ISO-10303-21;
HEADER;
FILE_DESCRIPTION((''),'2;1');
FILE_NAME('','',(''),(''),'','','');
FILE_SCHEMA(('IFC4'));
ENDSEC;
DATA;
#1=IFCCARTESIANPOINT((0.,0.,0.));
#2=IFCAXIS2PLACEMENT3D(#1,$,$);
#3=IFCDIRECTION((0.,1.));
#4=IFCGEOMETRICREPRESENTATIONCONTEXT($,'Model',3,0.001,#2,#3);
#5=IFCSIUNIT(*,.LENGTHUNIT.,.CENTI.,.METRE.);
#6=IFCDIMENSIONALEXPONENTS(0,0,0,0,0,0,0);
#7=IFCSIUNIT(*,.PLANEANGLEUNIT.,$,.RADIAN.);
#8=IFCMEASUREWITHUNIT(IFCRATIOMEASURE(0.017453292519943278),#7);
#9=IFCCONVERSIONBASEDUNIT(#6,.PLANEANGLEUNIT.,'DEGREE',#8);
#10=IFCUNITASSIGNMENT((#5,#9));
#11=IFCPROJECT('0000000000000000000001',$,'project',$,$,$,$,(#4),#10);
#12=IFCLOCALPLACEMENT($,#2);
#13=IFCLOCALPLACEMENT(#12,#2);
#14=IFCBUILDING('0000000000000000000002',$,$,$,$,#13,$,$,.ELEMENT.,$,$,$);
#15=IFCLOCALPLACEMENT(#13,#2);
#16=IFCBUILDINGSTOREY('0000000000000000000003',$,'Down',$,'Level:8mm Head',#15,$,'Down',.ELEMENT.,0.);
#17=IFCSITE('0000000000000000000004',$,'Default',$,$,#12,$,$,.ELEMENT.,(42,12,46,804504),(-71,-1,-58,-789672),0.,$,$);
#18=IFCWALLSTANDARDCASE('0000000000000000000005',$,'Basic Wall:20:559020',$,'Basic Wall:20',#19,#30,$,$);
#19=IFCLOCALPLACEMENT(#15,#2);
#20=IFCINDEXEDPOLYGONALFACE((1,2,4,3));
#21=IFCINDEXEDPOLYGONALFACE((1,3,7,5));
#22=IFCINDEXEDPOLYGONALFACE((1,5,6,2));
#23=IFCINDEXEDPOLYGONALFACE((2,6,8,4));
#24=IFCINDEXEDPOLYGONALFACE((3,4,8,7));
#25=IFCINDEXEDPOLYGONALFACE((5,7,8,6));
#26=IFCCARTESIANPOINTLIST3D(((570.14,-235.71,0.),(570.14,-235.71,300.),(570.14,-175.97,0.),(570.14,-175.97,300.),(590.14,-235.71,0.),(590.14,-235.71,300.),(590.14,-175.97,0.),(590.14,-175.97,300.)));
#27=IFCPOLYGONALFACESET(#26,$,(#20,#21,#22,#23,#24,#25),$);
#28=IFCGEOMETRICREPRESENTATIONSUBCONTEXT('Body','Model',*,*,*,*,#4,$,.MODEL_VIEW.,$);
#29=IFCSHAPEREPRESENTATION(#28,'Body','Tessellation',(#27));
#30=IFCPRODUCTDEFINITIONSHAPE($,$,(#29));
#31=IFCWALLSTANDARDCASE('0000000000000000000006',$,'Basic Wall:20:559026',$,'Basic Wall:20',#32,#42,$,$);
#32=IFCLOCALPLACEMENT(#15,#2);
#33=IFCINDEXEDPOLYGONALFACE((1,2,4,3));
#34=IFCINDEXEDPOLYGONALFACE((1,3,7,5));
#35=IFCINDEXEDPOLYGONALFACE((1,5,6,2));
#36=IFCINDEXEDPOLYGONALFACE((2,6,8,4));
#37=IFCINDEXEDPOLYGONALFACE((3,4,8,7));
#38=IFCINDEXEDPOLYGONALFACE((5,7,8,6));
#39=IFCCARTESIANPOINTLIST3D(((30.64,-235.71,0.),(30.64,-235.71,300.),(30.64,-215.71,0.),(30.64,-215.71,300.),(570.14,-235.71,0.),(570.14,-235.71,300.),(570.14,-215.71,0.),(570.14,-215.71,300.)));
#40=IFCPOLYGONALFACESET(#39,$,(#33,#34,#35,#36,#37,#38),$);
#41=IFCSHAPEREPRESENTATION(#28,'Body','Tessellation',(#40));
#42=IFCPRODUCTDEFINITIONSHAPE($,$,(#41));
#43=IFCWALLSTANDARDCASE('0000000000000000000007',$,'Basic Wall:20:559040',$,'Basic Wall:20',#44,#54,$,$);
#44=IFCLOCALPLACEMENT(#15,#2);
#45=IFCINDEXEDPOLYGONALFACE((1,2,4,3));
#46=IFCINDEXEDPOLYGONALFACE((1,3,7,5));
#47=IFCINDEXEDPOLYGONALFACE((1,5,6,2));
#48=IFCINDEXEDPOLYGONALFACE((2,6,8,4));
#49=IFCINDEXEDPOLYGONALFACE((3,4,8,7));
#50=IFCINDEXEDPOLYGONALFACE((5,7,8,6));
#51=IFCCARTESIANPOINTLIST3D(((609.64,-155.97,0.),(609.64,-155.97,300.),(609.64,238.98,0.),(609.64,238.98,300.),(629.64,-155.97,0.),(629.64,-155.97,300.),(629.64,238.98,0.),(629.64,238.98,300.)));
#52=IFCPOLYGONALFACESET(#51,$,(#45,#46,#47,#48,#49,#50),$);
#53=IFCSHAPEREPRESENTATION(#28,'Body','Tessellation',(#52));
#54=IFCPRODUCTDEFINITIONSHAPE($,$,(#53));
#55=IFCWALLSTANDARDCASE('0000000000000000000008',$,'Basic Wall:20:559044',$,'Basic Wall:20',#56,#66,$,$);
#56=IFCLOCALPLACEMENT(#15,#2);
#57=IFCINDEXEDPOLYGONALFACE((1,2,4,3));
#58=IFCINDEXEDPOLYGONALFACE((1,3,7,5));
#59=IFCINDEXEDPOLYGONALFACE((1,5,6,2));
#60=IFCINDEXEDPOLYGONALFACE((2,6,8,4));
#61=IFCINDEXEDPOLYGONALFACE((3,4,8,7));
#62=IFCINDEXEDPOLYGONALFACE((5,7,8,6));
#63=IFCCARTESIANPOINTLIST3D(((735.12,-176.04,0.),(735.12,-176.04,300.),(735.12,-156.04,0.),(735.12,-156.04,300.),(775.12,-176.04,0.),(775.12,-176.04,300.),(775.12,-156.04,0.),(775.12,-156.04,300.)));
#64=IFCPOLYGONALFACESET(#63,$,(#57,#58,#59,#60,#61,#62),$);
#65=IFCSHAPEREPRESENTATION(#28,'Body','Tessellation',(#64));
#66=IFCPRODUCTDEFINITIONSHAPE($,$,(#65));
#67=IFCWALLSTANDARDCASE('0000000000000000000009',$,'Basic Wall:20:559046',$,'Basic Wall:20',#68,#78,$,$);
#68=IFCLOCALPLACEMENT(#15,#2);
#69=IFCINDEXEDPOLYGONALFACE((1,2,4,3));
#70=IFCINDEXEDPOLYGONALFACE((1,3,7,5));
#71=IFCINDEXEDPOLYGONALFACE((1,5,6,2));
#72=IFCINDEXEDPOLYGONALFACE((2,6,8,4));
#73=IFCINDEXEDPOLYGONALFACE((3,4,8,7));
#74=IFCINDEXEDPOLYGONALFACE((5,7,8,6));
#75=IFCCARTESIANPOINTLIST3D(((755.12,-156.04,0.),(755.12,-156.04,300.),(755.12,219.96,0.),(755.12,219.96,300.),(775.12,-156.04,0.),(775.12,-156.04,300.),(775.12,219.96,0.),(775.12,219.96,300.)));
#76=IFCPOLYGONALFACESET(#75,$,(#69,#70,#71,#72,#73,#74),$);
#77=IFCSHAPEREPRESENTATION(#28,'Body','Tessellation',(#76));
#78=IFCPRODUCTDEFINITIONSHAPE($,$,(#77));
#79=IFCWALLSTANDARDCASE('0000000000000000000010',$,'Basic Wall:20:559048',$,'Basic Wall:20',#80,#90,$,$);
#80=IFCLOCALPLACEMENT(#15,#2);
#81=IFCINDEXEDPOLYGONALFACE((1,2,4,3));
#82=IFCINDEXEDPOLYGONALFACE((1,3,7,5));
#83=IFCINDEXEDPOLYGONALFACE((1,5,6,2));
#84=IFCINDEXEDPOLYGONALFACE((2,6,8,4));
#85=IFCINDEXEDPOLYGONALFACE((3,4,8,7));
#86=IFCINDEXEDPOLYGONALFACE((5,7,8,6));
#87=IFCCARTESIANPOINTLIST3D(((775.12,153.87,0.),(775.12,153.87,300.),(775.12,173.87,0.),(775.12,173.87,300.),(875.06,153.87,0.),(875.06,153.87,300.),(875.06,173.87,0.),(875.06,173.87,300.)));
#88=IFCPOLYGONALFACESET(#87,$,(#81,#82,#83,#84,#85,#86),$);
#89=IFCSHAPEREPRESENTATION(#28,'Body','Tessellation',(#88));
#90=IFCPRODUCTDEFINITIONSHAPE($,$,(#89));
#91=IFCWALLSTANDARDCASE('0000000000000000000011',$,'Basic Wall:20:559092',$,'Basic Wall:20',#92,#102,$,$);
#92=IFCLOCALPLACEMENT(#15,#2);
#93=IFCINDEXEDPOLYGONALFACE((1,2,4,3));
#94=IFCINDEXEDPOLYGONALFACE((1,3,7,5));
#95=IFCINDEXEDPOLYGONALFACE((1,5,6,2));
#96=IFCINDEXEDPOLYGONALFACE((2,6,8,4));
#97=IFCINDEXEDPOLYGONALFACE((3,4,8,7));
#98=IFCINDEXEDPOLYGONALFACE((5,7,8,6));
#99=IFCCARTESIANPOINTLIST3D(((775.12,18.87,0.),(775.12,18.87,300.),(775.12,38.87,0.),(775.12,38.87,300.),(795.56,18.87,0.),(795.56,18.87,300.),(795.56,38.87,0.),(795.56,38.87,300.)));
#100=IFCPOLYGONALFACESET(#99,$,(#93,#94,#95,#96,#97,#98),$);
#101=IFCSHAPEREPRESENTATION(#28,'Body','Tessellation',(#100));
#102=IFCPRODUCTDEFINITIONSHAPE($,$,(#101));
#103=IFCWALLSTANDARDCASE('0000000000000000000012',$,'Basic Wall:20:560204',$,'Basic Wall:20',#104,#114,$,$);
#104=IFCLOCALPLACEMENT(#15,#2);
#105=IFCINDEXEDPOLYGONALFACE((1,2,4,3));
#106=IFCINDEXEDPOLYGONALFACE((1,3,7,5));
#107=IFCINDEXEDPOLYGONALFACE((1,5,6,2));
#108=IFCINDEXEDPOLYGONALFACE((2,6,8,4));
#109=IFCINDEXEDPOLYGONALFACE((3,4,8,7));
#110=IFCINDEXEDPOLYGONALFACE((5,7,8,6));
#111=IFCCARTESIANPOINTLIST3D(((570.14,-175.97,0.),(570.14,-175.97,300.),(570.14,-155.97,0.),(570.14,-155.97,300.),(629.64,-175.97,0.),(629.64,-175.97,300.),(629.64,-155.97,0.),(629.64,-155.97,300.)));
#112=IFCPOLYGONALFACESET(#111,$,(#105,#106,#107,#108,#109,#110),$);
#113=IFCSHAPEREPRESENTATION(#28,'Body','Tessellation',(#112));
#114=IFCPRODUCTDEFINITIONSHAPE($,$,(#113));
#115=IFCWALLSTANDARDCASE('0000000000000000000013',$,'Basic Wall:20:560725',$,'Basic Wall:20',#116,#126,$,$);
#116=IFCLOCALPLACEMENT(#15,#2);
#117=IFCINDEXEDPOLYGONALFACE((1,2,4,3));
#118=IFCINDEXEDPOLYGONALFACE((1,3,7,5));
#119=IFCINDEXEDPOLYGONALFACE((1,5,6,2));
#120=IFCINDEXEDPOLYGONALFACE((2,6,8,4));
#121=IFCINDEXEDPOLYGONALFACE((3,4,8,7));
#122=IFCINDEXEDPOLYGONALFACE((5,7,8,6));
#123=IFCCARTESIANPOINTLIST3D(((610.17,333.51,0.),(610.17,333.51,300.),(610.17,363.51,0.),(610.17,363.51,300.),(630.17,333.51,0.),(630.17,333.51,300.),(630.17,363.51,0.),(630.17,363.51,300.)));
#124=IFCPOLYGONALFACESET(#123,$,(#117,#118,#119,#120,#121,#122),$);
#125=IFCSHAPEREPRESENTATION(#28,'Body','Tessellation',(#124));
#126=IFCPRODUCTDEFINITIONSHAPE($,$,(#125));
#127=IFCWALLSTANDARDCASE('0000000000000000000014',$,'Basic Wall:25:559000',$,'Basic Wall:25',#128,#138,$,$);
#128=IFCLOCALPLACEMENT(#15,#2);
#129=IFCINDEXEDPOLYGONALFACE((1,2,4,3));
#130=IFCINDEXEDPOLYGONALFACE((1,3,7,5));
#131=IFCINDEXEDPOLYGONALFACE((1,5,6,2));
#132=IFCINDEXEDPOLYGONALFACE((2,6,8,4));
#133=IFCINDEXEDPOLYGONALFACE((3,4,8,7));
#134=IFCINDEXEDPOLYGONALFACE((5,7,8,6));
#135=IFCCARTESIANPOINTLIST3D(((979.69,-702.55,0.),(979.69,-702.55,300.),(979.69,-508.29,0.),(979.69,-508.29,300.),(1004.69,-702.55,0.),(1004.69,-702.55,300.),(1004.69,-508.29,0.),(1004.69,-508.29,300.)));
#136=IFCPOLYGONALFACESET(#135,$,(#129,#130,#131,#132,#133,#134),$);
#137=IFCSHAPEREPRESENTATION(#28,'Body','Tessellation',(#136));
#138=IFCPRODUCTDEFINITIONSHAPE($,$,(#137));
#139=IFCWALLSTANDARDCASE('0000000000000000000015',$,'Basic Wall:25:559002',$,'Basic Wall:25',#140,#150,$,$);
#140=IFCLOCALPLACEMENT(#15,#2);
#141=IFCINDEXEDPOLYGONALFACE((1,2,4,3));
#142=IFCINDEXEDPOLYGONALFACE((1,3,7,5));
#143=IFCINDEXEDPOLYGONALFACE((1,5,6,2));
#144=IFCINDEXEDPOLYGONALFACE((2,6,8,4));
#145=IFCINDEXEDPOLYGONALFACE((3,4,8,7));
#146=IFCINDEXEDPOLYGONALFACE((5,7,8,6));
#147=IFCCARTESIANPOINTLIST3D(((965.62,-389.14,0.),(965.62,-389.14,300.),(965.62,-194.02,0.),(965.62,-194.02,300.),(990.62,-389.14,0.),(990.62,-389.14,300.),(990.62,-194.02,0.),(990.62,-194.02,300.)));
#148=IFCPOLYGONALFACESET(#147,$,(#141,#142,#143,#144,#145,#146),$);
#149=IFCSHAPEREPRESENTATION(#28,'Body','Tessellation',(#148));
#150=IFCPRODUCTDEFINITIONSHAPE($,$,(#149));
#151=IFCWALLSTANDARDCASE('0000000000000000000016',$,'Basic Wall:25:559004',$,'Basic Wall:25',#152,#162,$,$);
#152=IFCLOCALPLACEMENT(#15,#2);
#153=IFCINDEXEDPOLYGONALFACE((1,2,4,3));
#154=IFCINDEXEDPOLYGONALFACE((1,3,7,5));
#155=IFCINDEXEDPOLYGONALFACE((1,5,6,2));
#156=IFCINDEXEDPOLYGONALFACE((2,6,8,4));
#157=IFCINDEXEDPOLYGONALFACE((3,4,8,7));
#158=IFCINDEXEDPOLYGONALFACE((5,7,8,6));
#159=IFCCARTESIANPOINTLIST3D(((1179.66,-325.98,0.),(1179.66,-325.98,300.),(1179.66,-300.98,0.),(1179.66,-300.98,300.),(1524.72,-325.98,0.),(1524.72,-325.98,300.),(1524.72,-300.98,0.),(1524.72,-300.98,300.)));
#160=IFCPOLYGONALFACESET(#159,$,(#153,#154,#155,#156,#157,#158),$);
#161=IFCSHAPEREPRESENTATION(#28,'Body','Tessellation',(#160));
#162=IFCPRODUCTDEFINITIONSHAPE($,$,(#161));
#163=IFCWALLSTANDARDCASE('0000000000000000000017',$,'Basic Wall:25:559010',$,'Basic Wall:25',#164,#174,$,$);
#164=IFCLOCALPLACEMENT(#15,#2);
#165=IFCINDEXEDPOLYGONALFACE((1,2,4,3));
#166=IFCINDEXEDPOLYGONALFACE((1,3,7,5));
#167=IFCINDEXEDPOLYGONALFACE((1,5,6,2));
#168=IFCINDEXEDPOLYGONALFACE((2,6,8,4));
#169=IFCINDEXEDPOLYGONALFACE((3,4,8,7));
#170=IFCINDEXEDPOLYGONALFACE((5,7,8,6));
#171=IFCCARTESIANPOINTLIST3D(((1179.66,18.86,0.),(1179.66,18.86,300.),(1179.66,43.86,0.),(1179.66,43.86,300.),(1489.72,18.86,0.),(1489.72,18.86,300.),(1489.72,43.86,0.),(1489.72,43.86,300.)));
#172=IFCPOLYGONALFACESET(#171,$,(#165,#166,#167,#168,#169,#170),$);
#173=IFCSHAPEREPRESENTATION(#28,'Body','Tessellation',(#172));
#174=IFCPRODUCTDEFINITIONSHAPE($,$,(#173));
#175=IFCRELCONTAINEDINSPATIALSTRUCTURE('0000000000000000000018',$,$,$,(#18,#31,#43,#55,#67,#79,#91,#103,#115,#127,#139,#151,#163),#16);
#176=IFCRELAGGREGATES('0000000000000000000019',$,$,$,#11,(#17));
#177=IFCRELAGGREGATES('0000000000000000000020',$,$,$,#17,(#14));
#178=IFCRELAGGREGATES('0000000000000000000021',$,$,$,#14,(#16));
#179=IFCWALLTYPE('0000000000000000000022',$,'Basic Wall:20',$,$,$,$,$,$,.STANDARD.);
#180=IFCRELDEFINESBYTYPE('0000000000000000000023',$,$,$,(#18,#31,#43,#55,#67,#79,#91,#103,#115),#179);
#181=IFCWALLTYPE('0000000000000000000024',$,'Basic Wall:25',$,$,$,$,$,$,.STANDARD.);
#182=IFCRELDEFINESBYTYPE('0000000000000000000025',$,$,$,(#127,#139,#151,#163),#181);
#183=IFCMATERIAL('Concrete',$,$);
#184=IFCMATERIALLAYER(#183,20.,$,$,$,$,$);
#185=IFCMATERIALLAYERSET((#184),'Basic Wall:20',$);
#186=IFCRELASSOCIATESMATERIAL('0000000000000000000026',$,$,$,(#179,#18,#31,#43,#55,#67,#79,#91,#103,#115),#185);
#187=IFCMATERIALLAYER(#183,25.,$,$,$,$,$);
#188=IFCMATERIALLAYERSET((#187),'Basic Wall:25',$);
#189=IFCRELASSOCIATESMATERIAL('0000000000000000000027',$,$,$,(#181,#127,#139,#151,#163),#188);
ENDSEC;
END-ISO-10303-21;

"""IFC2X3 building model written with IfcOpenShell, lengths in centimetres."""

from ifc_helpers import new_model, entity, si_unit, converted_unit, direction, frame, frame_2d, origin, place, context, subcontext, project, spatial, rectangle, extrude, material, layer, layer_set, layer_usage, type_object, element, save


model = new_model("IFC2X3")

# Units and contexts
model_context = context("Model", 3, precision=0.001, world=origin(), true_north=direction((0.0, 1.0)))
body_context = subcontext(model_context, "Body", "Model", "MODEL_VIEW")
ifc_project = project(units=[si_unit("LENGTHUNIT", "METRE", prefix="CENTI"), converted_unit("PLANEANGLEUNIT", "DEGREE", entity("IfcRatioMeasure", 0.017453292519943278), si_unit("PLANEANGLEUNIT", "RADIAN"), dimensions=[0, 0, 0, 0, 0, 0, 0])], contexts=[model_context])

# Site, building, storey
site_placement = place(None, origin())
site = spatial("IfcSite", under=ifc_project, at=site_placement, Name="Default", CompositionType="ELEMENT", RefLatitude=(42, 12, 46, 804504), RefLongitude=(-71, -1, -58, -789672), RefElevation=0.0)
building_placement = place(site_placement, origin())
building = spatial("IfcBuilding", under=site, at=building_placement, CompositionType="ELEMENT")
storey_placement = place(building_placement, origin())
storey = spatial("IfcBuildingStorey", under=building, at=storey_placement, Name="Down", ObjectType="Level:8mm Head", LongName="Down", CompositionType="ELEMENT", Elevation=0.0)

# Walls
ifc_material = material(Name="Concrete")
ifc_layer_1 = layer(ifc_material, 20.0)
ifc_layer_set_1 = layer_set([ifc_layer_1], Name="Basic Wall:20")
wall_type_1 = type_object("IfcWallType", Name="Basic Wall:20", PredefinedType="STANDARD", material=ifc_layer_set_1)
ifc_layer_usage_1 = layer_usage(ifc_layer_set_1, "AXIS2", "POSITIVE", -10.0)
wall_1_placement = place(storey_placement, frame((580.14, -235.71, 0.0), z_axis=(0.0, 0.0, 1.0), x_axis=(0.0, 1.0, 0.0)))
element("IfcWallStandardCase", 1, at=wall_1_placement, inside=storey, type_object=wall_type_1, material=ifc_layer_usage_1, Name="Basic Wall:20:559020", ObjectType="Basic Wall:20", context=body_context, shape_type="SweptSolid", body=[
    extrude(rectangle(XDim=59.73, YDim=20.0, at=frame_2d((29.87, 0.0), x_axis=(-1.0, 0.0))), origin(), (0.0, 0.0, 1.0), 300.0),
])
ifc_layer_usage_2 = layer_usage(ifc_layer_set_1, "AXIS2", "POSITIVE", -10.0)
wall_2_placement = place(storey_placement, frame((570.14, -225.71, 0.0), z_axis=(0.0, 0.0, 1.0), x_axis=(-1.0, 0.0, 0.0)))
element("IfcWallStandardCase", 2, at=wall_2_placement, inside=storey, type_object=wall_type_1, material=ifc_layer_usage_2, Name="Basic Wall:20:559026", ObjectType="Basic Wall:20", context=body_context, shape_type="SweptSolid", body=[
    extrude(rectangle(XDim=539.5, YDim=20.0, at=frame_2d((269.75, 0.0), x_axis=(-1.0, 0.0))), origin(), (0.0, 0.0, 1.0), 300.0),
])
ifc_layer_usage_3 = layer_usage(ifc_layer_set_1, "AXIS2", "NEGATIVE", 10.0)
wall_3_placement = place(storey_placement, frame((619.64, 238.98, 0.0), z_axis=(0.0, 0.0, 1.0), x_axis=(0.0, -1.0, 0.0)))
element("IfcWallStandardCase", 3, at=wall_3_placement, inside=storey, type_object=wall_type_1, material=ifc_layer_usage_3, Name="Basic Wall:20:559040", ObjectType="Basic Wall:20", context=body_context, shape_type="SweptSolid", body=[
    extrude(rectangle(XDim=394.95, YDim=20.0, at=frame_2d((197.48, 0.0), x_axis=(-1.0, 0.0))), origin(), (0.0, 0.0, 1.0), 300.0),
])
ifc_layer_usage_4 = layer_usage(ifc_layer_set_1, "AXIS2", "NEGATIVE", 10.0)
wall_4_placement = place(storey_placement, frame((735.12, -166.04, 0.0)))
element("IfcWallStandardCase", 4, at=wall_4_placement, inside=storey, type_object=wall_type_1, material=ifc_layer_usage_4, Name="Basic Wall:20:559044", ObjectType="Basic Wall:20", context=body_context, shape_type="SweptSolid", body=[
    extrude(rectangle(XDim=40.0, YDim=20.0, at=frame_2d((20.0, 0.0), x_axis=(-1.0, 0.0))), origin(), (0.0, 0.0, 1.0), 300.0),
])
ifc_layer_usage_5 = layer_usage(ifc_layer_set_1, "AXIS2", "POSITIVE", -10.0)
wall_5_placement = place(storey_placement, frame((765.12, -156.04, 0.0), z_axis=(0.0, 0.0, 1.0), x_axis=(0.0, 1.0, 0.0)))
element("IfcWallStandardCase", 5, at=wall_5_placement, inside=storey, type_object=wall_type_1, material=ifc_layer_usage_5, Name="Basic Wall:20:559046", ObjectType="Basic Wall:20", context=body_context, shape_type="SweptSolid", body=[
    extrude(rectangle(XDim=376.0, YDim=20.0, at=frame_2d((188.0, 0.0), x_axis=(-1.0, 0.0))), origin(), (0.0, 0.0, 1.0), 300.0),
])
ifc_layer_usage_6 = layer_usage(ifc_layer_set_1, "AXIS2", "NEGATIVE", 10.0)
wall_6_placement = place(storey_placement, frame((775.12, 163.87, 0.0)))
element("IfcWallStandardCase", 6, at=wall_6_placement, inside=storey, type_object=wall_type_1, material=ifc_layer_usage_6, Name="Basic Wall:20:559048", ObjectType="Basic Wall:20", context=body_context, shape_type="SweptSolid", body=[
    extrude(rectangle(XDim=99.94, YDim=20.0, at=frame_2d((49.97, 0.0), x_axis=(-1.0, 0.0))), origin(), (0.0, 0.0, 1.0), 300.0),
])
ifc_layer_usage_7 = layer_usage(ifc_layer_set_1, "AXIS2", "NEGATIVE", 10.0)
wall_7_placement = place(storey_placement, frame((775.12, 28.87, 0.0)))
element("IfcWallStandardCase", 7, at=wall_7_placement, inside=storey, type_object=wall_type_1, material=ifc_layer_usage_7, Name="Basic Wall:20:559092", ObjectType="Basic Wall:20", context=body_context, shape_type="SweptSolid", body=[
    extrude(rectangle(XDim=20.44, YDim=20.0, at=frame_2d((10.22, 0.0), x_axis=(-1.0, 0.0))), origin(), (0.0, 0.0, 1.0), 300.0),
])
ifc_layer_usage_8 = layer_usage(ifc_layer_set_1, "AXIS2", "NEGATIVE", 10.0)
wall_8_placement = place(storey_placement, frame((570.14, -165.97, 0.0)))
element("IfcWallStandardCase", 8, at=wall_8_placement, inside=storey, type_object=wall_type_1, material=ifc_layer_usage_8, Name="Basic Wall:20:560204", ObjectType="Basic Wall:20", context=body_context, shape_type="SweptSolid", body=[
    extrude(rectangle(XDim=59.5, YDim=20.0, at=frame_2d((29.75, 0.0), x_axis=(-1.0, 0.0))), origin(), (0.0, 0.0, 1.0), 300.0),
])
ifc_layer_usage_9 = layer_usage(ifc_layer_set_1, "AXIS2", "NEGATIVE", 10.0)
wall_9_placement = place(storey_placement, frame((620.17, 333.51, 0.0), z_axis=(0.0, 0.0, 1.0), x_axis=(0.0, 1.0, 0.0)))
element("IfcWallStandardCase", 9, at=wall_9_placement, inside=storey, type_object=wall_type_1, material=ifc_layer_usage_9, Name="Basic Wall:20:560725", ObjectType="Basic Wall:20", context=body_context, shape_type="SweptSolid", body=[
    extrude(rectangle(XDim=30.0, YDim=20.0, at=frame_2d((15.0, 0.0), x_axis=(-1.0, 0.0))), origin(), (0.0, 0.0, 1.0), 300.0),
])
ifc_layer_2 = layer(ifc_material, 25.0)
ifc_layer_set_2 = layer_set([ifc_layer_2], Name="Basic Wall:25")
ifc_layer_usage_10 = layer_usage(ifc_layer_set_2, "AXIS2", "POSITIVE", -12.5)
wall_type_2 = type_object("IfcWallType", Name="Basic Wall:25", PredefinedType="STANDARD", material=ifc_layer_set_2)
wall_10_placement = place(storey_placement, frame((992.19, -702.55, 0.0), z_axis=(0.0, 0.0, 1.0), x_axis=(0.0, 1.0, 0.0)))
element("IfcWallStandardCase", 10, at=wall_10_placement, inside=storey, type_object=wall_type_2, material=ifc_layer_usage_10, Name="Basic Wall:25:559000", ObjectType="Basic Wall:25", context=body_context, shape_type="SweptSolid", body=[
    extrude(rectangle(XDim=194.25, YDim=25.0, at=frame_2d((97.13, 0.0), x_axis=(-1.0, 0.0))), origin(), (0.0, 0.0, 1.0), 300.0),
])
ifc_layer_usage_11 = layer_usage(ifc_layer_set_2, "AXIS2", "NEGATIVE", 12.5)
wall_11_placement = place(storey_placement, frame((978.12, -389.14, 0.0), z_axis=(0.0, 0.0, 1.0), x_axis=(0.0, 1.0, 0.0)))
element("IfcWallStandardCase", 11, at=wall_11_placement, inside=storey, type_object=wall_type_2, material=ifc_layer_usage_11, Name="Basic Wall:25:559002", ObjectType="Basic Wall:25", context=body_context, shape_type="SweptSolid", body=[
    extrude(rectangle(XDim=195.12, YDim=25.0, at=frame_2d((97.56, 0.0), x_axis=(-1.0, 0.0))), origin(), (0.0, 0.0, 1.0), 300.0),
])
ifc_layer_usage_12 = layer_usage(ifc_layer_set_2, "AXIS2", "POSITIVE", -12.5)
wall_12_placement = place(storey_placement, frame((1179.66, -313.48, 0.0)))
element("IfcWallStandardCase", 12, at=wall_12_placement, inside=storey, type_object=wall_type_2, material=ifc_layer_usage_12, Name="Basic Wall:25:559004", ObjectType="Basic Wall:25", context=body_context, shape_type="SweptSolid", body=[
    extrude(rectangle(XDim=345.06, YDim=25.0, at=frame_2d((172.53, 0.0), x_axis=(-1.0, 0.0))), origin(), (0.0, 0.0, 1.0), 300.0),
])
ifc_layer_usage_13 = layer_usage(ifc_layer_set_2, "AXIS2", "POSITIVE", -12.5)
wall_13_placement = place(storey_placement, frame((1489.72, 31.36, 0.0), z_axis=(0.0, 0.0, 1.0), x_axis=(-1.0, 0.0, 0.0)))
element("IfcWallStandardCase", 13, at=wall_13_placement, inside=storey, type_object=wall_type_2, material=ifc_layer_usage_13, Name="Basic Wall:25:559010", ObjectType="Basic Wall:25", context=body_context, shape_type="SweptSolid", body=[
    extrude(rectangle(XDim=310.06, YDim=25.0, at=frame_2d((155.03, 0.0), x_axis=(-1.0, 0.0))), origin(), (0.0, 0.0, 1.0), 300.0),
])

save(model, "model.ifc")
